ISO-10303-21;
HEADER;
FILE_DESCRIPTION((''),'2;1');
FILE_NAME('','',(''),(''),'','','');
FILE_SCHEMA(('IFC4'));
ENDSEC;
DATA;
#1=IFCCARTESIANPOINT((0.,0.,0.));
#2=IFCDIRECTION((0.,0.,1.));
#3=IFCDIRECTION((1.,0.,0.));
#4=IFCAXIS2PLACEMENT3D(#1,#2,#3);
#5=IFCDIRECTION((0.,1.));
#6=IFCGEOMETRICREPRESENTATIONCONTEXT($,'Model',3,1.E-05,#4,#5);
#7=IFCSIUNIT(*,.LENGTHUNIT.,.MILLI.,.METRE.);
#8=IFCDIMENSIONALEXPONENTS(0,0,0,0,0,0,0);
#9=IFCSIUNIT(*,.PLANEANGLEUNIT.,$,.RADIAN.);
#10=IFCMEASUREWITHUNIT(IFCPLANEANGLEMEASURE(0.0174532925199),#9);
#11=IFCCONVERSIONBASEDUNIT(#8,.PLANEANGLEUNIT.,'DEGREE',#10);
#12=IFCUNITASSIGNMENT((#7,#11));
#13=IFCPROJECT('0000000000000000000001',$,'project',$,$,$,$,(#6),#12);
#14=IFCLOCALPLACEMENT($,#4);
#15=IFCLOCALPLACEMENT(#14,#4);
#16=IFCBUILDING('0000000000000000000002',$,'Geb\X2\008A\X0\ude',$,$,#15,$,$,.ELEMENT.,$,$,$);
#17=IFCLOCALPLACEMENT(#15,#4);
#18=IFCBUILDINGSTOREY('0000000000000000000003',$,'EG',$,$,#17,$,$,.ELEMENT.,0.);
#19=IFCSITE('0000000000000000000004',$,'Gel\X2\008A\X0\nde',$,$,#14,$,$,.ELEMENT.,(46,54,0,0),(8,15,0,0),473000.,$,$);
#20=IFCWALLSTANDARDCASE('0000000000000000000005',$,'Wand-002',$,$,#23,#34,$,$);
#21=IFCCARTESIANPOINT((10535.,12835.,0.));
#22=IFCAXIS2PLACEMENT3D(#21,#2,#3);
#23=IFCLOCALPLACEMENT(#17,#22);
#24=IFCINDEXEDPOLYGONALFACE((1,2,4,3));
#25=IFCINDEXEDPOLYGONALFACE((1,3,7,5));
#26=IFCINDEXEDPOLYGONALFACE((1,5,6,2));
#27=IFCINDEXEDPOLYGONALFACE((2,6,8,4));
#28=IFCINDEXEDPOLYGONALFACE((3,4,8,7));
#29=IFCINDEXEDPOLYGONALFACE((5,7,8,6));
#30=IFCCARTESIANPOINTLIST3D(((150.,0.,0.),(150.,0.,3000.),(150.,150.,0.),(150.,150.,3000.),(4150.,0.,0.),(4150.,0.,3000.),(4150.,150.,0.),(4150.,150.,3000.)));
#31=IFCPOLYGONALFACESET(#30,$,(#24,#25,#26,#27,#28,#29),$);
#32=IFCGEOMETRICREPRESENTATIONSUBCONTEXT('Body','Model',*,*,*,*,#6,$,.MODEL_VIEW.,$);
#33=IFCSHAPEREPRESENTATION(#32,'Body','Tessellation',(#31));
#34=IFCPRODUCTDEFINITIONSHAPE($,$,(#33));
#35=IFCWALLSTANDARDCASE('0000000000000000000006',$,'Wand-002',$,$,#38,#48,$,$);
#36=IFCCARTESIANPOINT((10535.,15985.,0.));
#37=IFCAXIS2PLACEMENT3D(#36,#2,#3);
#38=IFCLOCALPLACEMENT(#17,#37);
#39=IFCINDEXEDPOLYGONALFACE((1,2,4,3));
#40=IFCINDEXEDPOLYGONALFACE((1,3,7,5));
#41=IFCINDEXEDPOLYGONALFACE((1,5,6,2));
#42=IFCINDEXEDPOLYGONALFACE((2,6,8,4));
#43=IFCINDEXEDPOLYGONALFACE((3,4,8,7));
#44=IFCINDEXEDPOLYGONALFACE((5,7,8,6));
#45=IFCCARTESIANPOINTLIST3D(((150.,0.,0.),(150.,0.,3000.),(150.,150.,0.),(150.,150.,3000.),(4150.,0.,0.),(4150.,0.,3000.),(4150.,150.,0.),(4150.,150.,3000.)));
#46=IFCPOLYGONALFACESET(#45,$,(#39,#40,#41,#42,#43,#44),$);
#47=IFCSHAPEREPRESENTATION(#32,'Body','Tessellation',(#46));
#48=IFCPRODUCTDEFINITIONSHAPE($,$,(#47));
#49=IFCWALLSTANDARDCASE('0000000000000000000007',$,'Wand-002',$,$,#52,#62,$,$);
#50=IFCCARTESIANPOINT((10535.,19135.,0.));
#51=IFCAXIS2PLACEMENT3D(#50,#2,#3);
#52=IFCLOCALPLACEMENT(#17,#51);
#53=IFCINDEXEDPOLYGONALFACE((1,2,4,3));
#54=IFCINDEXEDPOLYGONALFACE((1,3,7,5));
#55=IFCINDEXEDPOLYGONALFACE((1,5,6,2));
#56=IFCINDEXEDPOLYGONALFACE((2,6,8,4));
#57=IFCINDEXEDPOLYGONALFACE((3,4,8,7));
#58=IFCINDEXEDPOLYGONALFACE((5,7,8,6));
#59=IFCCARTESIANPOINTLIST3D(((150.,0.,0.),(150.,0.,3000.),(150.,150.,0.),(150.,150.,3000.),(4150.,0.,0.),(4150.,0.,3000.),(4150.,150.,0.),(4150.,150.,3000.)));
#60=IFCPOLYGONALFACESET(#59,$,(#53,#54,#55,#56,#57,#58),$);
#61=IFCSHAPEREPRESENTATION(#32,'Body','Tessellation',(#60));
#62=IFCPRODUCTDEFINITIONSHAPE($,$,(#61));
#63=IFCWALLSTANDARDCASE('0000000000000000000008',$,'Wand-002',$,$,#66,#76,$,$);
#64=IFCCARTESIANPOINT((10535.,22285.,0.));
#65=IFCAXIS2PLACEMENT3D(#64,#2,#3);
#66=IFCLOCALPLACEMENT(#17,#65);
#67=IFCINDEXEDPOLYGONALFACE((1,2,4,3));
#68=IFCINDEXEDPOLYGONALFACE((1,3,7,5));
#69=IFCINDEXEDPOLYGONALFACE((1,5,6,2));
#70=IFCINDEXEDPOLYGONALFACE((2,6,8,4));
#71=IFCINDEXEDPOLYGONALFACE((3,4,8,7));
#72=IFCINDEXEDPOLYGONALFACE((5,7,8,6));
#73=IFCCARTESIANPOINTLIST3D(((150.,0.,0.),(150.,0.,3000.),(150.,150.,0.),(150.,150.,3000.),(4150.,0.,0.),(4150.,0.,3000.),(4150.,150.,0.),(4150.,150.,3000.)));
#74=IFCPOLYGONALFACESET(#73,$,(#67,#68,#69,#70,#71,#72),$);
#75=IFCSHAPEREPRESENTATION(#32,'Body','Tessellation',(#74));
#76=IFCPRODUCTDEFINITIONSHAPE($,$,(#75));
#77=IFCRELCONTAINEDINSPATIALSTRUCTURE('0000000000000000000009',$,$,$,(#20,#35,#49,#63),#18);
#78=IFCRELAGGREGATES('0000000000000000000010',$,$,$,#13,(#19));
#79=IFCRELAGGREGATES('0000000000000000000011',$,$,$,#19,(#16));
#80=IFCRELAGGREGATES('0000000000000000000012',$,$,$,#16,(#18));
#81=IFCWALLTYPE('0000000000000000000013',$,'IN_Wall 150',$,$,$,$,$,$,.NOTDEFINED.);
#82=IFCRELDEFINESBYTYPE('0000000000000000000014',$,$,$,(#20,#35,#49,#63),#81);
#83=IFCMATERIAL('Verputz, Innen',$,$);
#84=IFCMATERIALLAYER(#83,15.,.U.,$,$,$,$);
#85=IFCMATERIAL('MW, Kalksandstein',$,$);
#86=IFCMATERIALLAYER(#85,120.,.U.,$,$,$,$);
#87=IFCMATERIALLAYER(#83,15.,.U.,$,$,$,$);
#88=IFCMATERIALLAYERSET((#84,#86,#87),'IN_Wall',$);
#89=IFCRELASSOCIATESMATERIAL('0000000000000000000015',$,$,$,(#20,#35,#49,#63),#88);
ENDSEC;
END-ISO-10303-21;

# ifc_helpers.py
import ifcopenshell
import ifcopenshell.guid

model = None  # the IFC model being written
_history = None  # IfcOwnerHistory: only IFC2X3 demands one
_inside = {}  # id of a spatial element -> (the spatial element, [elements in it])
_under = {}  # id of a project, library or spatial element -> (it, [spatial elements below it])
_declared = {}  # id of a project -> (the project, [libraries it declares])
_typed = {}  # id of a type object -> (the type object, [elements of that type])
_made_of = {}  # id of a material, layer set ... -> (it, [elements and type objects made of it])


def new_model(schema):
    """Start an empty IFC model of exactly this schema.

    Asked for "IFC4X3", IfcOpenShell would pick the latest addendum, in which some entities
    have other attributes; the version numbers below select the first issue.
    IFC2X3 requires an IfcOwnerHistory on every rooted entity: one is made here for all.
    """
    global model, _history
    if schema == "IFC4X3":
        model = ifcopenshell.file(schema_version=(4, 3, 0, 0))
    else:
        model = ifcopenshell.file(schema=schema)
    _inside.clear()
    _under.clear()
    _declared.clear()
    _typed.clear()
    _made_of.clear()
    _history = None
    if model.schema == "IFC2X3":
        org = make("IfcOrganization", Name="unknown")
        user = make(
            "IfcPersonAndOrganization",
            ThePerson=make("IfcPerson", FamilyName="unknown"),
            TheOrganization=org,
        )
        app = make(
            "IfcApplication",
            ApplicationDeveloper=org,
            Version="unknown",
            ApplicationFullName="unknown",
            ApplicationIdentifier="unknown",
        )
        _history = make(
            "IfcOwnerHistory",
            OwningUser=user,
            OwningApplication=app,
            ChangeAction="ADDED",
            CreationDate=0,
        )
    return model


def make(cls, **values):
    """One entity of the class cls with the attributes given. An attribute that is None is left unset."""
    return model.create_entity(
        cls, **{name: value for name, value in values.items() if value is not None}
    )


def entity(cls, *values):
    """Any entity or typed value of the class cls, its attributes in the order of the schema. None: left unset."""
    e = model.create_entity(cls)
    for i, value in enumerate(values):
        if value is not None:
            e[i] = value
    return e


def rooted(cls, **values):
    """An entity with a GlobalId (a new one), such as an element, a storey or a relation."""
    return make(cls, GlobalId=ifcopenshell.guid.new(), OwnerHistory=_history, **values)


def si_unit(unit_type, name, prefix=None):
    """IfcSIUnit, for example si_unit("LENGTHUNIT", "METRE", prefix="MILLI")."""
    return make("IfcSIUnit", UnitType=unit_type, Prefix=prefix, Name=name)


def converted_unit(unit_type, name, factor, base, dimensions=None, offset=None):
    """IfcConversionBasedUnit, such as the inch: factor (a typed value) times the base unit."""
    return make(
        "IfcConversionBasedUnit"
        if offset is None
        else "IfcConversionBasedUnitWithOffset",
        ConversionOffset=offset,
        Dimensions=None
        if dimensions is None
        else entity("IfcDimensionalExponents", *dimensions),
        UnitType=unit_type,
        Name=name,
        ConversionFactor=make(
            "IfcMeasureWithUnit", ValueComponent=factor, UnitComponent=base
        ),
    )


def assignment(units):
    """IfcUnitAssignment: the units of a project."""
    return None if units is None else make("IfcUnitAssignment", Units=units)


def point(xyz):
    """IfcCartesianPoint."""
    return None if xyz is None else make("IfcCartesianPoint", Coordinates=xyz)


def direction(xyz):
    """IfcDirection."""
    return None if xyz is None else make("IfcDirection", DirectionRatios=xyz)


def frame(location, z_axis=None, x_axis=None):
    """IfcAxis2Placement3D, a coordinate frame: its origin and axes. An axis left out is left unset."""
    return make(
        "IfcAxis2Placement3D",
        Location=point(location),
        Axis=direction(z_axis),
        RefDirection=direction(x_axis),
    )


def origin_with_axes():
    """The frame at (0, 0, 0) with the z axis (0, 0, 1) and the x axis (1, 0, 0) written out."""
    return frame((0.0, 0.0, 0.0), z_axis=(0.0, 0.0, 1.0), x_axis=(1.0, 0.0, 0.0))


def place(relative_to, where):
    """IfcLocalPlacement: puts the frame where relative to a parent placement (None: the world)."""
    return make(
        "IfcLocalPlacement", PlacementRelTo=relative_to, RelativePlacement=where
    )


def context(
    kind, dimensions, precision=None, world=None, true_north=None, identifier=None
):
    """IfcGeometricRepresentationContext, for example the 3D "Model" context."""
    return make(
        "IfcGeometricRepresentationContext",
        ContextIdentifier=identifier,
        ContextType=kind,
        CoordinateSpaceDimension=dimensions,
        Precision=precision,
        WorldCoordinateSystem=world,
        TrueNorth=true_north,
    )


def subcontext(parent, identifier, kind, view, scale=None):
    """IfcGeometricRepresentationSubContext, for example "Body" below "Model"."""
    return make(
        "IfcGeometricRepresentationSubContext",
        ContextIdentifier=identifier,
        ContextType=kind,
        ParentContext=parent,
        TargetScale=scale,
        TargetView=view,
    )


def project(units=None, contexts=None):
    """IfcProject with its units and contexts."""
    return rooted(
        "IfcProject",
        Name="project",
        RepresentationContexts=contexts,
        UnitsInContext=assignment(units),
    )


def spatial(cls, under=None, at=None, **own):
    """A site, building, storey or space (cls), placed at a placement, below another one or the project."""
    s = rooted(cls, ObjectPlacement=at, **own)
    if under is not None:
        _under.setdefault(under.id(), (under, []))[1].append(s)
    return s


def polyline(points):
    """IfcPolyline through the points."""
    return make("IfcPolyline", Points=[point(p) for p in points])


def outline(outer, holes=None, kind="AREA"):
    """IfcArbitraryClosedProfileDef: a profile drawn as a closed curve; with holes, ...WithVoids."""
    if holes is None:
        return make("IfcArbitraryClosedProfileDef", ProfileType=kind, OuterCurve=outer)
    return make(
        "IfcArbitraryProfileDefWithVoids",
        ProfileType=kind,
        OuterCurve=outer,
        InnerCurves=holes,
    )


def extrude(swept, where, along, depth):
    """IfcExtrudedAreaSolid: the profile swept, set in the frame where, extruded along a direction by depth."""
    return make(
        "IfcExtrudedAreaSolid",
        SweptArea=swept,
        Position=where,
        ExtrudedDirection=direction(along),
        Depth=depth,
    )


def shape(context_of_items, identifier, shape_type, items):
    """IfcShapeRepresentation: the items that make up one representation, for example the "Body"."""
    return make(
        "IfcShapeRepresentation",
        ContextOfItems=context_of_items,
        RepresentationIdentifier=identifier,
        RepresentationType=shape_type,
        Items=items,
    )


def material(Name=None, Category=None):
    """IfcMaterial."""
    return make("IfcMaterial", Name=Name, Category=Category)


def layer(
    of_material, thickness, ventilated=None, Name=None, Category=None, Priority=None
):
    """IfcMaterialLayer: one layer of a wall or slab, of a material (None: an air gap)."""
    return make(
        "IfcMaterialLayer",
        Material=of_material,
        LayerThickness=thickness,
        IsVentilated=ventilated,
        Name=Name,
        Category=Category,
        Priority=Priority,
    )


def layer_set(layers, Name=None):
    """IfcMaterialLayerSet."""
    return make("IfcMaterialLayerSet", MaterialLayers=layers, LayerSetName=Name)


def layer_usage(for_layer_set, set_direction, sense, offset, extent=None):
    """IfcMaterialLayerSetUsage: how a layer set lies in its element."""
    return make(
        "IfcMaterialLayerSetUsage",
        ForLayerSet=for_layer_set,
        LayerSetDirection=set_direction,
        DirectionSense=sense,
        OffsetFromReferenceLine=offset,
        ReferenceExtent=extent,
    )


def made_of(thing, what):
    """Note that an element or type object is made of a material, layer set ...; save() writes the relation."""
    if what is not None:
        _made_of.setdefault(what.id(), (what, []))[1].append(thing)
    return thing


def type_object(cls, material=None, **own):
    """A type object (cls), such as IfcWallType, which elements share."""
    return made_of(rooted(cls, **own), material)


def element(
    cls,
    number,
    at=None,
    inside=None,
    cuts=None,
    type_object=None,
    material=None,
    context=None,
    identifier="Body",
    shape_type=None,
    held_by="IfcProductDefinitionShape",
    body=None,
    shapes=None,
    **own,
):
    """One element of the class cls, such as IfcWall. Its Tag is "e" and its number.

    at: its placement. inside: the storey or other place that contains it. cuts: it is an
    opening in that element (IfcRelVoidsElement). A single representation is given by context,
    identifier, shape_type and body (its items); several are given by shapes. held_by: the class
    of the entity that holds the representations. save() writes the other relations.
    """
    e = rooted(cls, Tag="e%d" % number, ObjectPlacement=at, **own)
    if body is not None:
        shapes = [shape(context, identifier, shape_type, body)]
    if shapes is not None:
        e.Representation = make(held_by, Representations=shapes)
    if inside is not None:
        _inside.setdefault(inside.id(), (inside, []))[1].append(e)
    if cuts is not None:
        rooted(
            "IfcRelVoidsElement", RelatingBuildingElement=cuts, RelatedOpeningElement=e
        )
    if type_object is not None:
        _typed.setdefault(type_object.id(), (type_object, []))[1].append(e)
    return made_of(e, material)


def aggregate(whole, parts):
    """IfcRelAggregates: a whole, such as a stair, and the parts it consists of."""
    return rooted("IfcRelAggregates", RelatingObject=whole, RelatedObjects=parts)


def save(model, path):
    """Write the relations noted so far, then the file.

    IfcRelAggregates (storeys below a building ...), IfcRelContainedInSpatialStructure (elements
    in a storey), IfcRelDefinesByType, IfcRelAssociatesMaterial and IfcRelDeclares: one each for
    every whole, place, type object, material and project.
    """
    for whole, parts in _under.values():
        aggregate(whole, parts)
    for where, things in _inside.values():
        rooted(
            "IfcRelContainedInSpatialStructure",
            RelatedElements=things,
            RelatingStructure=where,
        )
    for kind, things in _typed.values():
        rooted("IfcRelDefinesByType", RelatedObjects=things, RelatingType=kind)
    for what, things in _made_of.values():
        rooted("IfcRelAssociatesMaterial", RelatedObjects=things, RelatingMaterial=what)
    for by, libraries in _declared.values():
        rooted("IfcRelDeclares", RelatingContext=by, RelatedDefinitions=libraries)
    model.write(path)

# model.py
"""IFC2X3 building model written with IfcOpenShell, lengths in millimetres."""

from ifc_helpers import new_model, entity, si_unit, converted_unit, direction, frame, origin_with_axes, place, context, subcontext, project, spatial, polyline, outline, extrude, material, layer, layer_set, layer_usage, type_object, element, save


model = new_model("IFC2X3")

# Units and contexts
model_context = context("Model", 3, precision=1e-05, world=origin_with_axes(), true_north=direction((0.0, 1.0)))
body_context = subcontext(model_context, "Body", "Model", "MODEL_VIEW")
ifc_project = project(units=[si_unit("LENGTHUNIT", "METRE", prefix="MILLI"), converted_unit("PLANEANGLEUNIT", "DEGREE", entity("IfcPlaneAngleMeasure", 0.0174532925199), si_unit("PLANEANGLEUNIT", "RADIAN"), dimensions=[0, 0, 0, 0, 0, 0, 0])], contexts=[model_context])

# Site, building, storey
site_placement = place(None, origin_with_axes())
site = spatial("IfcSite", under=ifc_project, at=site_placement, Name="Gel\u008ande", CompositionType="ELEMENT", RefLatitude=(46, 54, 0, 0), RefLongitude=(8, 15, 0, 0), RefElevation=473000.0)
building_placement = place(site_placement, origin_with_axes())
building = spatial("IfcBuilding", under=site, at=building_placement, Name="Geb\u008aude", CompositionType="ELEMENT")
storey_placement = place(building_placement, origin_with_axes())
storey = spatial("IfcBuildingStorey", under=building, at=storey_placement, Name="EG", CompositionType="ELEMENT", Elevation=0.0)

# Shared definitions
ifc_material_1 = material(Name="Verputz, Innen")

# Shared definitions
ifc_layer_1 = layer(ifc_material_1, 15.0, ventilated="UNKNOWN")
ifc_material_2 = material(Name="MW, Kalksandstein")
ifc_layer_2 = layer(ifc_material_2, 120.0, ventilated="UNKNOWN")
ifc_layer_3 = layer(ifc_material_1, 15.0, ventilated="UNKNOWN")
ifc_layer_set_1 = layer_set([ifc_layer_1, ifc_layer_2, ifc_layer_3], Name="IN_Wall")
wall_type_1 = type_object("IfcWallType", Name="IN_Wall 150", PredefinedType="NOTDEFINED")

# Walls
ifc_layer_usage_1 = layer_usage(ifc_layer_set_1, "AXIS2", "POSITIVE", 0.0)
wall_1_placement = place(storey_placement, frame((10535.0, 12835.0, 0.0), z_axis=(0.0, 0.0, 1.0), x_axis=(1.0, 0.0, 0.0)))
element("IfcWallStandardCase", 1, at=wall_1_placement, inside=storey, type_object=wall_type_1, material=ifc_layer_usage_1, Name="Wand-002", context=body_context, shape_type="SweptSolid", body=[
    extrude(outline(polyline([(150.0, 0.0), (4150.0, 0.0), (4150.0, 150.0), (150.0, 150.0), (150.0, 0.0)])), origin_with_axes(), (0.0, 0.0, 1.0), 3000.0),
])
ifc_layer_usage_2 = layer_usage(ifc_layer_set_1, "AXIS2", "POSITIVE", 0.0)
wall_2_placement = place(storey_placement, frame((10535.0, 15985.0, 0.0), z_axis=(0.0, 0.0, 1.0), x_axis=(1.0, 0.0, 0.0)))
element("IfcWallStandardCase", 2, at=wall_2_placement, inside=storey, type_object=wall_type_1, material=ifc_layer_usage_2, Name="Wand-002", context=body_context, shape_type="SweptSolid", body=[
    extrude(outline(polyline([(150.0, 0.0), (4150.0, 0.0), (4150.0, 150.0), (150.0, 150.0), (150.0, 0.0)])), origin_with_axes(), (0.0, 0.0, 1.0), 3000.0),
])
ifc_layer_usage_3 = layer_usage(ifc_layer_set_1, "AXIS2", "POSITIVE", 0.0)
wall_3_placement = place(storey_placement, frame((10535.0, 19135.0, 0.0), z_axis=(0.0, 0.0, 1.0), x_axis=(1.0, 0.0, 0.0)))
element("IfcWallStandardCase", 3, at=wall_3_placement, inside=storey, type_object=wall_type_1, material=ifc_layer_usage_3, Name="Wand-002", context=body_context, shape_type="SweptSolid", body=[
    extrude(outline(polyline([(150.0, 0.0), (4150.0, 0.0), (4150.0, 150.0), (150.0, 150.0), (150.0, 0.0)])), origin_with_axes(), (0.0, 0.0, 1.0), 3000.0),
])
ifc_layer_usage_4 = layer_usage(ifc_layer_set_1, "AXIS2", "POSITIVE", 0.0)
wall_4_placement = place(storey_placement, frame((10535.0, 22285.0, 0.0), z_axis=(0.0, 0.0, 1.0), x_axis=(1.0, 0.0, 0.0)))
element("IfcWallStandardCase", 4, at=wall_4_placement, inside=storey, type_object=wall_type_1, material=ifc_layer_usage_4, Name="Wand-002", context=body_context, shape_type="SweptSolid", body=[
    extrude(outline(polyline([(150.0, 0.0), (4150.0, 0.0), (4150.0, 150.0), (150.0, 150.0), (150.0, 0.0)])), origin_with_axes(), (0.0, 0.0, 1.0), 3000.0),
])

save(model, "model.ifc")
